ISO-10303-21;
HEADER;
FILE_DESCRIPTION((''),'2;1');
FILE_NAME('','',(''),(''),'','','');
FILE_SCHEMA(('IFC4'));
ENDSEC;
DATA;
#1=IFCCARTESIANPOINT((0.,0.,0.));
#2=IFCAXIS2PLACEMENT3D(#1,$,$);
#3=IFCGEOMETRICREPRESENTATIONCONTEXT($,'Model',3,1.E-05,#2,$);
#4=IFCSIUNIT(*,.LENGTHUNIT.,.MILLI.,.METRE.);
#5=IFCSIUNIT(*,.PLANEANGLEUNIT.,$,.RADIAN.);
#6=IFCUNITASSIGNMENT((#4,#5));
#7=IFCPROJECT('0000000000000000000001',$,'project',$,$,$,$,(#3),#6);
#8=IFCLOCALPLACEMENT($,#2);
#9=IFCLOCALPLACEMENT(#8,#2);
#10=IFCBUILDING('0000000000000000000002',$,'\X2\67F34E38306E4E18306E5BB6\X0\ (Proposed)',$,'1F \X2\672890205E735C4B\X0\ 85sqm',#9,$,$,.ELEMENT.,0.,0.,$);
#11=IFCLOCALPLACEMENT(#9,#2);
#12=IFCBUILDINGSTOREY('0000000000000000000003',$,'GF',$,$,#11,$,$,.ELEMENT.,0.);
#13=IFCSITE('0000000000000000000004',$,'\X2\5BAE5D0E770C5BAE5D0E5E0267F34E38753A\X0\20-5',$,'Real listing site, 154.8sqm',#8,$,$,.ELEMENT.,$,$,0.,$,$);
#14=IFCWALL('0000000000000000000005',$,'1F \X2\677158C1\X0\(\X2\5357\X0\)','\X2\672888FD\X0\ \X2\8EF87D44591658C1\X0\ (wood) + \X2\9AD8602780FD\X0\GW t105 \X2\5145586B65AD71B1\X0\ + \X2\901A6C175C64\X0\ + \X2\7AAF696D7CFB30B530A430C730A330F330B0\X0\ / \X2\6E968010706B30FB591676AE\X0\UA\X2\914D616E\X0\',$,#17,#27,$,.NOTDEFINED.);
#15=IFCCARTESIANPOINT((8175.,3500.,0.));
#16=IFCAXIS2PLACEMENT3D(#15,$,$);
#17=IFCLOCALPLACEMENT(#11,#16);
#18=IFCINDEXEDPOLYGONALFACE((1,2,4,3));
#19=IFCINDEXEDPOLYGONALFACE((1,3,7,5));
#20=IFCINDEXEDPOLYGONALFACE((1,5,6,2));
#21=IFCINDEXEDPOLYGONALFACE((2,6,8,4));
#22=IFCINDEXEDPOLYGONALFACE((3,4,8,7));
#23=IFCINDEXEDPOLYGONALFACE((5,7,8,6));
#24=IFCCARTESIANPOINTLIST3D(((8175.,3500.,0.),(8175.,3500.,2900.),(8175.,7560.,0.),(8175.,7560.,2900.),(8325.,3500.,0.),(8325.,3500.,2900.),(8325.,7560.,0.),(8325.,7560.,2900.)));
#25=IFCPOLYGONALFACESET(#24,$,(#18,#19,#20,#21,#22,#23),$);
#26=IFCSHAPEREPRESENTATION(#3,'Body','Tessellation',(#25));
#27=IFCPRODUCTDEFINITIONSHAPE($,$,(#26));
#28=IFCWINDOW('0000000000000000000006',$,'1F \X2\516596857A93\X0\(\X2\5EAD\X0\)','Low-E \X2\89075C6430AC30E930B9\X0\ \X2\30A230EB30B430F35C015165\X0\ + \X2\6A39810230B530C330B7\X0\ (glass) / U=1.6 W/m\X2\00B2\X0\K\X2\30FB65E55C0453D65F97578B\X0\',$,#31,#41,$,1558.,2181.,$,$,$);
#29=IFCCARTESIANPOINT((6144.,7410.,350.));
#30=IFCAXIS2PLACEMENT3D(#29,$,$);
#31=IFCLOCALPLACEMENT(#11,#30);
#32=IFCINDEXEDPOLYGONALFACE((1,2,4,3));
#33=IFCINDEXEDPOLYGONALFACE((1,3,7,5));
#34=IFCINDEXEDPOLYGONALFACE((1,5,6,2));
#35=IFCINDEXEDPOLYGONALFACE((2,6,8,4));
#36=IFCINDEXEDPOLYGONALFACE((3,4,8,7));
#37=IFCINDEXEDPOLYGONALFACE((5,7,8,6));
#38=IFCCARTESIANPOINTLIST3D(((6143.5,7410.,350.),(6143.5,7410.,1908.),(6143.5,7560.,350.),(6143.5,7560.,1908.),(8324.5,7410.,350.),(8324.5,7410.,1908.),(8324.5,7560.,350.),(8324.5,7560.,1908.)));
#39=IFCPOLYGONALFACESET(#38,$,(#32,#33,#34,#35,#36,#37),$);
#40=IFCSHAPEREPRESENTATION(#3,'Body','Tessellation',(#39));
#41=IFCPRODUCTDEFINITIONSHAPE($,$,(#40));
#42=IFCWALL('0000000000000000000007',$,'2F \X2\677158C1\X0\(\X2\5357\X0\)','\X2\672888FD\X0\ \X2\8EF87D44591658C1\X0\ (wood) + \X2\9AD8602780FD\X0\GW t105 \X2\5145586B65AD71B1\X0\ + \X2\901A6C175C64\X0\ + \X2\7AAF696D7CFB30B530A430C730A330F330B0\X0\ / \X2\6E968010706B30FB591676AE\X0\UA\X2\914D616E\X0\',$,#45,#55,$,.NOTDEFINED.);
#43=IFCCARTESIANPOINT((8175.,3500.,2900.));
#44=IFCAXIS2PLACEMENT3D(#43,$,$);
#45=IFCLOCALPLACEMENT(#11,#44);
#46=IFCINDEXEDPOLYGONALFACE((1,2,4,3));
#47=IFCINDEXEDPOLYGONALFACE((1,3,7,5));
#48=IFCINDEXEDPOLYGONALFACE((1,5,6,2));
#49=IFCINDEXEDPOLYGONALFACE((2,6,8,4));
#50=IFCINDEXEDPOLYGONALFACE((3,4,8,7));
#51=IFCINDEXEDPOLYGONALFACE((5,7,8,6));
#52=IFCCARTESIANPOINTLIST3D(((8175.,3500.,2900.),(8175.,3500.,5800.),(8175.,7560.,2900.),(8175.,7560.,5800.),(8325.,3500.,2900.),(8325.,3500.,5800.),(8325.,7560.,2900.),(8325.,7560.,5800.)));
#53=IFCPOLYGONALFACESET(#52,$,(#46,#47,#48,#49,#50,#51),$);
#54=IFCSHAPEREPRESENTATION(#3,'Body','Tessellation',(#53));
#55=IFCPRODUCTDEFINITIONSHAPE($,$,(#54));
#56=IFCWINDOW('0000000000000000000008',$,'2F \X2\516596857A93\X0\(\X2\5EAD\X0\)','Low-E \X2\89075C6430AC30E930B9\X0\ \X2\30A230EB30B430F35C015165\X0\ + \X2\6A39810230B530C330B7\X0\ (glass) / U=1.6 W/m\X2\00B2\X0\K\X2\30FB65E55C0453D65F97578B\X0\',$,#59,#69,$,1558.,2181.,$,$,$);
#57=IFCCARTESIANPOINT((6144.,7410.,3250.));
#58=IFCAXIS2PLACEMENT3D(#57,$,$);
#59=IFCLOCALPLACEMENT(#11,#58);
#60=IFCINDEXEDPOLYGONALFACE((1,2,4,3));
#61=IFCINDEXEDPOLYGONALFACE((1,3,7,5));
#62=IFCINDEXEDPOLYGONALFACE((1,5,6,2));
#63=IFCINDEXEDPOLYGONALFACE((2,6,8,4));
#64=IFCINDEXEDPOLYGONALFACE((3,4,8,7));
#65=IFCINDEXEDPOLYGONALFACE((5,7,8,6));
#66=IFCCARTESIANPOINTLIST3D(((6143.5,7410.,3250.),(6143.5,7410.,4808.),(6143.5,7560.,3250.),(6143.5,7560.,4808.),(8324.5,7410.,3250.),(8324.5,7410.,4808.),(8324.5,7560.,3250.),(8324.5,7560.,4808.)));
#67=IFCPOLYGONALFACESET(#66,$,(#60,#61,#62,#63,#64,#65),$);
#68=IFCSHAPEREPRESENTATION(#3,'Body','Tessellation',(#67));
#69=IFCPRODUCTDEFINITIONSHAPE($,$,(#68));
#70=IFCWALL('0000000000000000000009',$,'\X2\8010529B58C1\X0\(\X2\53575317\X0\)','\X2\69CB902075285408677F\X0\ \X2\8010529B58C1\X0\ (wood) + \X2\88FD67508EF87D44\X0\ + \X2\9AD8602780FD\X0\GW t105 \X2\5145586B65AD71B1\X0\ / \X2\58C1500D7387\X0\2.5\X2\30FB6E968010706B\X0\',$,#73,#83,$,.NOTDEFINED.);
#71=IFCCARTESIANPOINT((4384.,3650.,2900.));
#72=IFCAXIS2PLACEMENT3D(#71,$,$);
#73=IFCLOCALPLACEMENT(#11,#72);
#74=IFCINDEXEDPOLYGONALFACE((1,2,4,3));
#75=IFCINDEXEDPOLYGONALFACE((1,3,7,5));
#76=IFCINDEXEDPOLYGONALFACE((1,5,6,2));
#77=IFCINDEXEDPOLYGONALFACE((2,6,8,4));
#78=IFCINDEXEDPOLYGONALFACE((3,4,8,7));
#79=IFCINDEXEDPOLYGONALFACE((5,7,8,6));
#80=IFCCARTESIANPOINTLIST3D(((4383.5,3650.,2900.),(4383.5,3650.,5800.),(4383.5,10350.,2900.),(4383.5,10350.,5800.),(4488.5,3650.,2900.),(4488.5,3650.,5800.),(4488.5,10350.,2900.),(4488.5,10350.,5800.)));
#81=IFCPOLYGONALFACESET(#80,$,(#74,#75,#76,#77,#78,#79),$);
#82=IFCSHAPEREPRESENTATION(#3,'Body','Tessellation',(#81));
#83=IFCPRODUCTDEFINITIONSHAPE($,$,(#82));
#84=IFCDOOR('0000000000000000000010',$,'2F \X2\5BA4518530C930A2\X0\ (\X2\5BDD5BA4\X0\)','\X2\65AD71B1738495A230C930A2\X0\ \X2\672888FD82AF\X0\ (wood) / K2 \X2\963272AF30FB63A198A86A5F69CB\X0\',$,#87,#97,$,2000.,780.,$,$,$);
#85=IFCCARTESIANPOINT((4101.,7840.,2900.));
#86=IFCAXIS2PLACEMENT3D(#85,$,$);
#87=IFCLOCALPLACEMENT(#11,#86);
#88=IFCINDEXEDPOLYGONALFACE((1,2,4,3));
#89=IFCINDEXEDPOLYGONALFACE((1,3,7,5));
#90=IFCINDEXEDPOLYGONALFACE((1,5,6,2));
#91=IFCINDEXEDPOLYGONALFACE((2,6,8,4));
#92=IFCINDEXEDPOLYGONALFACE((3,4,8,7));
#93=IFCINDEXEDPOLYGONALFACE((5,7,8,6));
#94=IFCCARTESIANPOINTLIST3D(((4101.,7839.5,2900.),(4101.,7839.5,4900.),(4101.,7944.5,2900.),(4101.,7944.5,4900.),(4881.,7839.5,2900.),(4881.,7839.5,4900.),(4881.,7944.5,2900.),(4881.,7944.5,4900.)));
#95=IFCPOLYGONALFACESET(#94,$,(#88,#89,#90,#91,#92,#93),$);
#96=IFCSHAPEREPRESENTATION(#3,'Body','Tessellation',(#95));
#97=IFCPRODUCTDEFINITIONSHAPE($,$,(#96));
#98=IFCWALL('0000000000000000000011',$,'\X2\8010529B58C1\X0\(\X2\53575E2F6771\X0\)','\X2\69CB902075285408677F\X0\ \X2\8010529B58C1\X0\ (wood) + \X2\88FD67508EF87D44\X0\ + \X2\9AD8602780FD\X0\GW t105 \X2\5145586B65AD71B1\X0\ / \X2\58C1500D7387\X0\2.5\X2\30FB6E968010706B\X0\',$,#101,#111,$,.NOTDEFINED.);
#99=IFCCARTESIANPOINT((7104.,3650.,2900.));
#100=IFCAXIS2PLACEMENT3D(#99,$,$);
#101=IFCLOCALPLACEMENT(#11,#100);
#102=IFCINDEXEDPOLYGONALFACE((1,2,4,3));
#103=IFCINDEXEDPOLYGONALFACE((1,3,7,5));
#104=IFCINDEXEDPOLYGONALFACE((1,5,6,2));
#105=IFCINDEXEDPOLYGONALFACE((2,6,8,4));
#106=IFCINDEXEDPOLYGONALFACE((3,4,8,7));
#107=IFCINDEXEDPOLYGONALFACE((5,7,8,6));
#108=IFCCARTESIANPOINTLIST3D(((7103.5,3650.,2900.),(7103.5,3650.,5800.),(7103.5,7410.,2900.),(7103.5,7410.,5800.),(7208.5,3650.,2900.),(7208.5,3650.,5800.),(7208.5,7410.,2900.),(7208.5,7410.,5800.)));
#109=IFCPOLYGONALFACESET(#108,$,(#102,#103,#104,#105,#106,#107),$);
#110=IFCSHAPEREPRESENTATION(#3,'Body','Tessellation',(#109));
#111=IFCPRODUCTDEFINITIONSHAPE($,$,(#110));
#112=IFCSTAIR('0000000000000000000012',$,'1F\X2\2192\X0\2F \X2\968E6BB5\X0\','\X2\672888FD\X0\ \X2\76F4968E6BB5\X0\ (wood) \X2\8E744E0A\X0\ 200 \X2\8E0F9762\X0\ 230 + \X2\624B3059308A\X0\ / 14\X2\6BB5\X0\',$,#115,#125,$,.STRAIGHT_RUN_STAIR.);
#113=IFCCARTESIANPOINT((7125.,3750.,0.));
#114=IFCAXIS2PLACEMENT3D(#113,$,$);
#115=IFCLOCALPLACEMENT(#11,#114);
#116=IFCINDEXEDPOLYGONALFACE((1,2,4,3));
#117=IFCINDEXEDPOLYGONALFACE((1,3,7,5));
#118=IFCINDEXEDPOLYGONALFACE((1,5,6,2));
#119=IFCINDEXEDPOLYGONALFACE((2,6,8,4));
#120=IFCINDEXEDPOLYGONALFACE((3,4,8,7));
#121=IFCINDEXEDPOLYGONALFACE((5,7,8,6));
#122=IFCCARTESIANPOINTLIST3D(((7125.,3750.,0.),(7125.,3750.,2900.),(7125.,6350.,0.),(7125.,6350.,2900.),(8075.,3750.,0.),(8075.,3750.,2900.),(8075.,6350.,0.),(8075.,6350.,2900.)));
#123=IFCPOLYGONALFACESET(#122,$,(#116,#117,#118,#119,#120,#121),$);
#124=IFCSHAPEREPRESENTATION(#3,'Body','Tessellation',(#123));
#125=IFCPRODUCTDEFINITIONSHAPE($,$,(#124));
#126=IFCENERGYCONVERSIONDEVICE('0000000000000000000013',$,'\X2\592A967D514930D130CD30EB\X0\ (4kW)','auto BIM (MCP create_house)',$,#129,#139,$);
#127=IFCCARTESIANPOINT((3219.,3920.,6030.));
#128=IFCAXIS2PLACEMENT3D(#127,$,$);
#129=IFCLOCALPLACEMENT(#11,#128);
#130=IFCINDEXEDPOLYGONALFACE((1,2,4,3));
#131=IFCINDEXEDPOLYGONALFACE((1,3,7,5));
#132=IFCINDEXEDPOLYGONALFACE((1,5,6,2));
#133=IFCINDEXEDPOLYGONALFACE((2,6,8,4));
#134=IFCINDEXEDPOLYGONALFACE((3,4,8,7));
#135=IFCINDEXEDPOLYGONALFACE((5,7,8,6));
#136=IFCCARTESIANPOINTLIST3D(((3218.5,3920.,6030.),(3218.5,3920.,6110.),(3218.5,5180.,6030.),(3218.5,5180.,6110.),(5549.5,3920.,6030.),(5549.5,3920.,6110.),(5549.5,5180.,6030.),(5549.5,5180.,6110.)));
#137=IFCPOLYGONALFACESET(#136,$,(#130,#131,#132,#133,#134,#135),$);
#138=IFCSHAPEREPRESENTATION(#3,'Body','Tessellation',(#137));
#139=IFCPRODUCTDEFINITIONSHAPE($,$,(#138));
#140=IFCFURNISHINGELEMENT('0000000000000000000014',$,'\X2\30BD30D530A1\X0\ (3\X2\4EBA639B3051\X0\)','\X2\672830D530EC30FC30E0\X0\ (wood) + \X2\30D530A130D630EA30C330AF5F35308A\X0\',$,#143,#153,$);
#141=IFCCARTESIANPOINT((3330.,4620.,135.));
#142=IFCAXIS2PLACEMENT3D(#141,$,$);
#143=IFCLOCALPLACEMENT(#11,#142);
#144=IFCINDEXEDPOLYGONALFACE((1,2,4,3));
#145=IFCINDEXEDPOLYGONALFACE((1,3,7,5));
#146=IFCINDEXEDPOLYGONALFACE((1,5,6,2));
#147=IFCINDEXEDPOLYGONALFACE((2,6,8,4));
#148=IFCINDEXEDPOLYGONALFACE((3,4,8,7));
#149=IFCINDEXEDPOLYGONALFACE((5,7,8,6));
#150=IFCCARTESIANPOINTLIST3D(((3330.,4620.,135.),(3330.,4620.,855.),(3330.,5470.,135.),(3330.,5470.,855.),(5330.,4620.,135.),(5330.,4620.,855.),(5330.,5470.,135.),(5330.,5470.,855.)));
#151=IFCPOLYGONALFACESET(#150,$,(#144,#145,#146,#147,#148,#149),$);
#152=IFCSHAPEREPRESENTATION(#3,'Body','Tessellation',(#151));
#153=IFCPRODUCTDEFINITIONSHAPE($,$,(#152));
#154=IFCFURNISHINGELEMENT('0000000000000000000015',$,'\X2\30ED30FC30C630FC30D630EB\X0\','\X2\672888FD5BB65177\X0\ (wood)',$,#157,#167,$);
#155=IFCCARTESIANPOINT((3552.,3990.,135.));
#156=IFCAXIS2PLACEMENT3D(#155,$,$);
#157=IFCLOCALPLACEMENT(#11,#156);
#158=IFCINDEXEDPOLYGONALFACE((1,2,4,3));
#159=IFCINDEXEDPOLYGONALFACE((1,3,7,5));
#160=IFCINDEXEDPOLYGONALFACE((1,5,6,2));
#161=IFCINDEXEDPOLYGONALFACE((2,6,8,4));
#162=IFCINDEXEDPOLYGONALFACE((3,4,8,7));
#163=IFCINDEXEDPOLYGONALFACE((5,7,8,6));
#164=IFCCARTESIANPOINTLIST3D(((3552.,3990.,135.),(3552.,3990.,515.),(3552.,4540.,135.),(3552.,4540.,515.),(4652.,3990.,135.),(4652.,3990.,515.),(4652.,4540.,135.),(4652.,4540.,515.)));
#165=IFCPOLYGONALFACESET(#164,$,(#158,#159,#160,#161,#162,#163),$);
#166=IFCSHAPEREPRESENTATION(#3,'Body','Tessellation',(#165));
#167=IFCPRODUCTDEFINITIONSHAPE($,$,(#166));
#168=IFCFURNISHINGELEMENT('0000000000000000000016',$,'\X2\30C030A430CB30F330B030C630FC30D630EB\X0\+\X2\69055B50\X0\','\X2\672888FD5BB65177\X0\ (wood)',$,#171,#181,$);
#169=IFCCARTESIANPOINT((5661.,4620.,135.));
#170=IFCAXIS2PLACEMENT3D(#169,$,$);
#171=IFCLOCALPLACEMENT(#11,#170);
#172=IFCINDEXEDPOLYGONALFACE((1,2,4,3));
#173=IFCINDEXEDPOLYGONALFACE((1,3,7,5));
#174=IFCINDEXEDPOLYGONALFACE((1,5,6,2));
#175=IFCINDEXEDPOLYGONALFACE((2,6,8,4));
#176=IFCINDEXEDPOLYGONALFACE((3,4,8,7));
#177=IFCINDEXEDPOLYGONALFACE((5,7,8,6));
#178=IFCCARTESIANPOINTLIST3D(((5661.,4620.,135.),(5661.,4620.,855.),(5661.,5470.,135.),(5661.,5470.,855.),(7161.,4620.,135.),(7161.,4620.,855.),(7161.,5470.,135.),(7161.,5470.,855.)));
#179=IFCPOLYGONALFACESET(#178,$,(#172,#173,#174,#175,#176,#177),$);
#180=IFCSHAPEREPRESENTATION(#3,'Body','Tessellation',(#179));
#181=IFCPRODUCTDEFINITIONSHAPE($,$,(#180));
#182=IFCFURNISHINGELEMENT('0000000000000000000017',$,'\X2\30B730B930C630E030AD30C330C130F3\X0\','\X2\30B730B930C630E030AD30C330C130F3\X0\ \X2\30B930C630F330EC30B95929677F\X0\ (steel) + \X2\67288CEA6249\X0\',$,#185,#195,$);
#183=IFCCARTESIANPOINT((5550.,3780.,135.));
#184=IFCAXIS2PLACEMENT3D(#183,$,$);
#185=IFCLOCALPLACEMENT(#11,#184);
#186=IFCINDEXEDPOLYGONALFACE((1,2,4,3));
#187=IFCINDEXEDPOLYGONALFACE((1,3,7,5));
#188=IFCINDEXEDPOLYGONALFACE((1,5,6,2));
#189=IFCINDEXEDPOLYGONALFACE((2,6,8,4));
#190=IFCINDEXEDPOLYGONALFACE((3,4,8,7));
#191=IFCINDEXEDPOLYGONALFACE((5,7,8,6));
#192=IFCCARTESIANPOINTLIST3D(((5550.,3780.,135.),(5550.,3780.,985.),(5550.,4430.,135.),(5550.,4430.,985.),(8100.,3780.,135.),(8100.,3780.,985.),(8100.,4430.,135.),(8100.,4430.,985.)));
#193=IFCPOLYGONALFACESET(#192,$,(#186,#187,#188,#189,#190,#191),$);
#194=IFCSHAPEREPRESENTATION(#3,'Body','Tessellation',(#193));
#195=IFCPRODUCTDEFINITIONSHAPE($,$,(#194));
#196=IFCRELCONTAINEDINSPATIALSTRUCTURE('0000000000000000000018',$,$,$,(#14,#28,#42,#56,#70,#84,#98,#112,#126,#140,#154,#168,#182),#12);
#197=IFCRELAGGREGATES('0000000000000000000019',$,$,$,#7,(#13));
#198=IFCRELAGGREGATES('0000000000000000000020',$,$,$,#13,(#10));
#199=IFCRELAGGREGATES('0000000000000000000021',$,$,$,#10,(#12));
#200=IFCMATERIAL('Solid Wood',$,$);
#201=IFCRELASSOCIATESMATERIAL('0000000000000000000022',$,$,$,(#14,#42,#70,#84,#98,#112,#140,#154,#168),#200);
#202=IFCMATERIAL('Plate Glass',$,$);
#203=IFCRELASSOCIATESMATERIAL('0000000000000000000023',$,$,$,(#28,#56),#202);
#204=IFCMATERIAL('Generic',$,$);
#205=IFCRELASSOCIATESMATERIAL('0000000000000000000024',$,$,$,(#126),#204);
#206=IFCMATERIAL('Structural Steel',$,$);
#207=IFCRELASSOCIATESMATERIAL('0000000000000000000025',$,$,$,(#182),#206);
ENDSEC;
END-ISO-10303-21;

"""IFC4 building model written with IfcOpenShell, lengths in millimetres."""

from ifc_helpers import new_model, si_unit, frame, frame_2d, origin, place, context, project, spatial, rectangle, extrude, material, element, fill, save


model = new_model("IFC4")

# Units and contexts
model_context = context("Model", 3, precision=1e-05, world=origin())
ifc_project = project(units=[si_unit("LENGTHUNIT", "METRE", prefix="MILLI"), si_unit("PLANEANGLEUNIT", "RADIAN")], contexts=[model_context])

# Site, building, storey
site_placement = place(None, origin())
site = spatial("IfcSite", under=ifc_project, at=site_placement, Name="宮崎県宮崎市柳丸町20-5", ObjectType="Real listing site, 154.8sqm", CompositionType="ELEMENT", RefElevation=0.0)
building_placement = place(site_placement, origin())
building = spatial("IfcBuilding", under=site, at=building_placement, Name="柳丸の丘の家 (Proposed)", ObjectType="1F 木造平屋 85sqm", CompositionType="ELEMENT", ElevationOfRefHeight=0.0, ElevationOfTerrain=0.0)
storey_placement = place(building_placement, origin())
storey = spatial("IfcBuildingStorey", under=building, at=storey_placement, Name="GF", CompositionType="ELEMENT", Elevation=0.0)

# Wall, opening, window
ifc_material_1 = material(Name="Solid Wood")
wall_1_placement = place(storey_placement, frame((8175.0, 3500.0, 0.0)))
wall_1 = element("IfcWall", 1, at=wall_1_placement, inside=storey, material=ifc_material_1, Name="1F 東壁(南)", Description="木製 軸組外壁 (wood) + 高性能GW t105 充填断熱 + 通気層 + 窯業系サイディング / 準耐火・外皮UA配慮", PredefinedType="NOTDEFINED", context=model_context, shape_type="SweptSolid", body=[
    extrude(rectangle(XDim=150.0, YDim=4060.0, at=frame_2d((75.0, 2030.0))), frame((8175.0, 3500.0, 0.0)), (0.0, 0.0, 1.0), 2900.0),
])
opening_1_placement = place(storey_placement, frame((6144.0, 7410.0, 350.0)))
opening_1 = element("IfcOpeningElement", 2, at=opening_1_placement, cuts=wall_1, PredefinedType="NOTDEFINED", context=model_context, shape_type="SweptSolid", body=[
    extrude(rectangle(XDim=2181.0, YDim=150.0, at=frame_2d((1090.0, 75.0))), frame((6144.0, 7410.0, 350.0)), (0.0, 0.0, 1.0), 1558.0),
])
ifc_material_2 = material(Name="Plate Glass")
window_1_placement = place(storey_placement, frame((6144.0, 7410.0, 350.0)))
window_1 = element("IfcWindow", 3, at=window_1_placement, inside=storey, material=ifc_material_2, Name="1F 入隅窓(庭)", Description="Low-E 複層ガラス アルゴン封入 + 樹脂サッシ (glass) / U=1.6 W/m²K・日射取得型", OverallHeight=1558.0, OverallWidth=2181.0, context=model_context, shape_type="SweptSolid", body=[
    extrude(rectangle(XDim=2181.0, YDim=150.0, at=frame_2d((1090.0, 75.0))), frame((6144.0, 7410.0, 350.0)), (0.0, 0.0, 1.0), 1558.0),
])
fill(opening_1, window_1)

# Wall, opening, window
wall_2_placement = place(storey_placement, frame((8175.0, 3500.0, 2900.0)))
wall_2 = element("IfcWall", 4, at=wall_2_placement, inside=storey, material=ifc_material_1, Name="2F 東壁(南)", Description="木製 軸組外壁 (wood) + 高性能GW t105 充填断熱 + 通気層 + 窯業系サイディング / 準耐火・外皮UA配慮", PredefinedType="NOTDEFINED", context=model_context, shape_type="SweptSolid", body=[
    extrude(rectangle(XDim=150.0, YDim=4060.0, at=frame_2d((75.0, 2030.0))), frame((8175.0, 3500.0, 2900.0)), (0.0, 0.0, 1.0), 2900.0),
])
opening_2_placement = place(storey_placement, frame((6144.0, 7410.0, 3250.0)))
opening_2 = element("IfcOpeningElement", 5, at=opening_2_placement, cuts=wall_2, PredefinedType="NOTDEFINED", context=model_context, shape_type="SweptSolid", body=[
    extrude(rectangle(XDim=2181.0, YDim=150.0, at=frame_2d((1090.0, 75.0))), frame((6144.0, 7410.0, 3250.0)), (0.0, 0.0, 1.0), 1558.0),
])
window_2_placement = place(storey_placement, frame((6144.0, 7410.0, 3250.0)))
window_2 = element("IfcWindow", 6, at=window_2_placement, inside=storey, material=ifc_material_2, Name="2F 入隅窓(庭)", Description="Low-E 複層ガラス アルゴン封入 + 樹脂サッシ (glass) / U=1.6 W/m²K・日射取得型", OverallHeight=1558.0, OverallWidth=2181.0, context=model_context, shape_type="SweptSolid", body=[
    extrude(rectangle(XDim=2181.0, YDim=150.0, at=frame_2d((1090.0, 75.0))), frame((6144.0, 7410.0, 3250.0)), (0.0, 0.0, 1.0), 1558.0),
])
fill(opening_2, window_2)

# Wall, opening, door
wall_3_placement = place(storey_placement, frame((4384.0, 3650.0, 2900.0)))
wall_3 = element("IfcWall", 7, at=wall_3_placement, inside=storey, material=ifc_material_1, Name="耐力壁(南北)", Description="構造用合板 耐力壁 (wood) + 製材軸組 + 高性能GW t105 充填断熱 / 壁倍率2.5・準耐火", PredefinedType="NOTDEFINED", context=model_context, shape_type="SweptSolid", body=[
    extrude(rectangle(XDim=105.0, YDim=6700.0, at=frame_2d((52.0, 3350.0))), frame((4384.0, 3650.0, 2900.0)), (0.0, 0.0, 1.0), 2900.0),
])
opening_3_placement = place(storey_placement, frame((4101.0, 7840.0, 2900.0)))
opening_3 = element("IfcOpeningElement", 8, at=opening_3_placement, cuts=wall_3, PredefinedType="NOTDEFINED", context=model_context, shape_type="SweptSolid", body=[
    extrude(rectangle(XDim=780.0, YDim=105.0, at=frame_2d((390.0, 52.0))), frame((4101.0, 7840.0, 2900.0)), (0.0, 0.0, 1.0), 2000.0),
])
door_1_placement = place(storey_placement, frame((4101.0, 7840.0, 2900.0)))
door_1 = element("IfcDoor", 9, at=door_1_placement, inside=storey, material=ifc_material_1, Name="2F 室内ドア (寝室)", Description="断熱玄関ドア 木製芯 (wood) / K2 防犯・採風機構", OverallHeight=2000.0, OverallWidth=780.0, context=model_context, shape_type="SweptSolid", body=[
    extrude(rectangle(XDim=780.0, YDim=105.0, at=frame_2d((390.0, 52.0))), frame((4101.0, 7840.0, 2900.0)), (0.0, 0.0, 1.0), 2000.0),
])
fill(opening_3, door_1)

# Wall
wall_4_placement = place(storey_placement, frame((7104.0, 3650.0, 2900.0)))
element("IfcWall", 10, at=wall_4_placement, inside=storey, material=ifc_material_1, Name="耐力壁(南帯東)", Description="構造用合板 耐力壁 (wood) + 製材軸組 + 高性能GW t105 充填断熱 / 壁倍率2.5・準耐火", PredefinedType="NOTDEFINED", context=model_context, shape_type="SweptSolid", body=[
    extrude(rectangle(XDim=105.0, YDim=3760.0, at=frame_2d((52.0, 1880.0))), frame((7104.0, 3650.0, 2900.0)), (0.0, 0.0, 1.0), 2900.0),
])

# Stair
stair_placement = place(storey_placement, frame((7125.0, 3750.0, 0.0)))
element("IfcStair", 11, at=stair_placement, inside=storey, material=ifc_material_1, Name="1F→2F 階段", Description="木製 直階段 (wood) 蹴上 200 踏面 230 + 手すり / 14段", PredefinedType="STRAIGHT_RUN_STAIR", context=model_context, shape_type="SweptSolid", body=[
    extrude(rectangle(XDim=950.0, YDim=2600.0, at=frame_2d((475.0, 1300.0))), frame((7125.0, 3750.0, 0.0)), (0.0, 0.0, 1.0), 2900.0),
])

# Energy conversion device
ifc_material_3 = material(Name="Generic")
energy_conversion_device_placement = place(storey_placement, frame((3219.0, 3920.0, 6030.0)))
element("IfcEnergyConversionDevice", 12, at=energy_conversion_device_placement, inside=storey, material=ifc_material_3, Name="太陽光パネル (4kW)", Description="auto BIM (MCP create_house)", context=model_context, shape_type="SweptSolid", body=[
    extrude(rectangle(XDim=2331.0, YDim=1260.0, at=frame_2d((1165.0, 630.0))), frame((3219.0, 3920.0, 6030.0)), (0.0, 0.0, 1.0), 80.0),
])

# Furnishing elements
furnishing_1_placement = place(storey_placement, frame((3330.0, 4620.0, 135.0)))
element("IfcFurnishingElement", 13, at=furnishing_1_placement, inside=storey, material=ifc_material_1, Name="ソファ (3人掛け)", Description="木フレーム (wood) + ファブリック張り", context=model_context, shape_type="SweptSolid", body=[
    extrude(rectangle(XDim=2000.0, YDim=850.0, at=frame_2d((1000.0, 425.0))), frame((3330.0, 4620.0, 135.0)), (0.0, 0.0, 1.0), 720.0),
])
furnishing_2_placement = place(storey_placement, frame((3552.0, 3990.0, 135.0)))
element("IfcFurnishingElement", 14, at=furnishing_2_placement, inside=storey, material=ifc_material_1, Name="ローテーブル", Description="木製家具 (wood)", context=model_context, shape_type="SweptSolid", body=[
    extrude(rectangle(XDim=1100.0, YDim=550.0, at=frame_2d((550.0, 275.0))), frame((3552.0, 3990.0, 135.0)), (0.0, 0.0, 1.0), 380.0),
])
furnishing_3_placement = place(storey_placement, frame((5661.0, 4620.0, 135.0)))
element("IfcFurnishingElement", 15, at=furnishing_3_placement, inside=storey, material=ifc_material_1, Name="ダイニングテーブル+椅子", Description="木製家具 (wood)", context=model_context, shape_type="SweptSolid", body=[
    extrude(rectangle(XDim=1500.0, YDim=850.0, at=frame_2d((750.0, 425.0))), frame((5661.0, 4620.0, 135.0)), (0.0, 0.0, 1.0), 720.0),
])
ifc_material_4 = material(Name="Structural Steel")
furnishing_4_placement = place(storey_placement, frame((5550.0, 3780.0, 135.0)))
element("IfcFurnishingElement", 16, at=furnishing_4_placement, inside=storey, material=ifc_material_4, Name="システムキッチン", Description="システムキッチン ステンレス天板 (steel) + 木質扉", context=model_context, shape_type="SweptSolid", body=[
    extrude(rectangle(XDim=2550.0, YDim=650.0, at=frame_2d((1275.0, 325.0))), frame((5550.0, 3780.0, 135.0)), (0.0, 0.0, 1.0), 850.0),
])

save(model, "model.ifc")
